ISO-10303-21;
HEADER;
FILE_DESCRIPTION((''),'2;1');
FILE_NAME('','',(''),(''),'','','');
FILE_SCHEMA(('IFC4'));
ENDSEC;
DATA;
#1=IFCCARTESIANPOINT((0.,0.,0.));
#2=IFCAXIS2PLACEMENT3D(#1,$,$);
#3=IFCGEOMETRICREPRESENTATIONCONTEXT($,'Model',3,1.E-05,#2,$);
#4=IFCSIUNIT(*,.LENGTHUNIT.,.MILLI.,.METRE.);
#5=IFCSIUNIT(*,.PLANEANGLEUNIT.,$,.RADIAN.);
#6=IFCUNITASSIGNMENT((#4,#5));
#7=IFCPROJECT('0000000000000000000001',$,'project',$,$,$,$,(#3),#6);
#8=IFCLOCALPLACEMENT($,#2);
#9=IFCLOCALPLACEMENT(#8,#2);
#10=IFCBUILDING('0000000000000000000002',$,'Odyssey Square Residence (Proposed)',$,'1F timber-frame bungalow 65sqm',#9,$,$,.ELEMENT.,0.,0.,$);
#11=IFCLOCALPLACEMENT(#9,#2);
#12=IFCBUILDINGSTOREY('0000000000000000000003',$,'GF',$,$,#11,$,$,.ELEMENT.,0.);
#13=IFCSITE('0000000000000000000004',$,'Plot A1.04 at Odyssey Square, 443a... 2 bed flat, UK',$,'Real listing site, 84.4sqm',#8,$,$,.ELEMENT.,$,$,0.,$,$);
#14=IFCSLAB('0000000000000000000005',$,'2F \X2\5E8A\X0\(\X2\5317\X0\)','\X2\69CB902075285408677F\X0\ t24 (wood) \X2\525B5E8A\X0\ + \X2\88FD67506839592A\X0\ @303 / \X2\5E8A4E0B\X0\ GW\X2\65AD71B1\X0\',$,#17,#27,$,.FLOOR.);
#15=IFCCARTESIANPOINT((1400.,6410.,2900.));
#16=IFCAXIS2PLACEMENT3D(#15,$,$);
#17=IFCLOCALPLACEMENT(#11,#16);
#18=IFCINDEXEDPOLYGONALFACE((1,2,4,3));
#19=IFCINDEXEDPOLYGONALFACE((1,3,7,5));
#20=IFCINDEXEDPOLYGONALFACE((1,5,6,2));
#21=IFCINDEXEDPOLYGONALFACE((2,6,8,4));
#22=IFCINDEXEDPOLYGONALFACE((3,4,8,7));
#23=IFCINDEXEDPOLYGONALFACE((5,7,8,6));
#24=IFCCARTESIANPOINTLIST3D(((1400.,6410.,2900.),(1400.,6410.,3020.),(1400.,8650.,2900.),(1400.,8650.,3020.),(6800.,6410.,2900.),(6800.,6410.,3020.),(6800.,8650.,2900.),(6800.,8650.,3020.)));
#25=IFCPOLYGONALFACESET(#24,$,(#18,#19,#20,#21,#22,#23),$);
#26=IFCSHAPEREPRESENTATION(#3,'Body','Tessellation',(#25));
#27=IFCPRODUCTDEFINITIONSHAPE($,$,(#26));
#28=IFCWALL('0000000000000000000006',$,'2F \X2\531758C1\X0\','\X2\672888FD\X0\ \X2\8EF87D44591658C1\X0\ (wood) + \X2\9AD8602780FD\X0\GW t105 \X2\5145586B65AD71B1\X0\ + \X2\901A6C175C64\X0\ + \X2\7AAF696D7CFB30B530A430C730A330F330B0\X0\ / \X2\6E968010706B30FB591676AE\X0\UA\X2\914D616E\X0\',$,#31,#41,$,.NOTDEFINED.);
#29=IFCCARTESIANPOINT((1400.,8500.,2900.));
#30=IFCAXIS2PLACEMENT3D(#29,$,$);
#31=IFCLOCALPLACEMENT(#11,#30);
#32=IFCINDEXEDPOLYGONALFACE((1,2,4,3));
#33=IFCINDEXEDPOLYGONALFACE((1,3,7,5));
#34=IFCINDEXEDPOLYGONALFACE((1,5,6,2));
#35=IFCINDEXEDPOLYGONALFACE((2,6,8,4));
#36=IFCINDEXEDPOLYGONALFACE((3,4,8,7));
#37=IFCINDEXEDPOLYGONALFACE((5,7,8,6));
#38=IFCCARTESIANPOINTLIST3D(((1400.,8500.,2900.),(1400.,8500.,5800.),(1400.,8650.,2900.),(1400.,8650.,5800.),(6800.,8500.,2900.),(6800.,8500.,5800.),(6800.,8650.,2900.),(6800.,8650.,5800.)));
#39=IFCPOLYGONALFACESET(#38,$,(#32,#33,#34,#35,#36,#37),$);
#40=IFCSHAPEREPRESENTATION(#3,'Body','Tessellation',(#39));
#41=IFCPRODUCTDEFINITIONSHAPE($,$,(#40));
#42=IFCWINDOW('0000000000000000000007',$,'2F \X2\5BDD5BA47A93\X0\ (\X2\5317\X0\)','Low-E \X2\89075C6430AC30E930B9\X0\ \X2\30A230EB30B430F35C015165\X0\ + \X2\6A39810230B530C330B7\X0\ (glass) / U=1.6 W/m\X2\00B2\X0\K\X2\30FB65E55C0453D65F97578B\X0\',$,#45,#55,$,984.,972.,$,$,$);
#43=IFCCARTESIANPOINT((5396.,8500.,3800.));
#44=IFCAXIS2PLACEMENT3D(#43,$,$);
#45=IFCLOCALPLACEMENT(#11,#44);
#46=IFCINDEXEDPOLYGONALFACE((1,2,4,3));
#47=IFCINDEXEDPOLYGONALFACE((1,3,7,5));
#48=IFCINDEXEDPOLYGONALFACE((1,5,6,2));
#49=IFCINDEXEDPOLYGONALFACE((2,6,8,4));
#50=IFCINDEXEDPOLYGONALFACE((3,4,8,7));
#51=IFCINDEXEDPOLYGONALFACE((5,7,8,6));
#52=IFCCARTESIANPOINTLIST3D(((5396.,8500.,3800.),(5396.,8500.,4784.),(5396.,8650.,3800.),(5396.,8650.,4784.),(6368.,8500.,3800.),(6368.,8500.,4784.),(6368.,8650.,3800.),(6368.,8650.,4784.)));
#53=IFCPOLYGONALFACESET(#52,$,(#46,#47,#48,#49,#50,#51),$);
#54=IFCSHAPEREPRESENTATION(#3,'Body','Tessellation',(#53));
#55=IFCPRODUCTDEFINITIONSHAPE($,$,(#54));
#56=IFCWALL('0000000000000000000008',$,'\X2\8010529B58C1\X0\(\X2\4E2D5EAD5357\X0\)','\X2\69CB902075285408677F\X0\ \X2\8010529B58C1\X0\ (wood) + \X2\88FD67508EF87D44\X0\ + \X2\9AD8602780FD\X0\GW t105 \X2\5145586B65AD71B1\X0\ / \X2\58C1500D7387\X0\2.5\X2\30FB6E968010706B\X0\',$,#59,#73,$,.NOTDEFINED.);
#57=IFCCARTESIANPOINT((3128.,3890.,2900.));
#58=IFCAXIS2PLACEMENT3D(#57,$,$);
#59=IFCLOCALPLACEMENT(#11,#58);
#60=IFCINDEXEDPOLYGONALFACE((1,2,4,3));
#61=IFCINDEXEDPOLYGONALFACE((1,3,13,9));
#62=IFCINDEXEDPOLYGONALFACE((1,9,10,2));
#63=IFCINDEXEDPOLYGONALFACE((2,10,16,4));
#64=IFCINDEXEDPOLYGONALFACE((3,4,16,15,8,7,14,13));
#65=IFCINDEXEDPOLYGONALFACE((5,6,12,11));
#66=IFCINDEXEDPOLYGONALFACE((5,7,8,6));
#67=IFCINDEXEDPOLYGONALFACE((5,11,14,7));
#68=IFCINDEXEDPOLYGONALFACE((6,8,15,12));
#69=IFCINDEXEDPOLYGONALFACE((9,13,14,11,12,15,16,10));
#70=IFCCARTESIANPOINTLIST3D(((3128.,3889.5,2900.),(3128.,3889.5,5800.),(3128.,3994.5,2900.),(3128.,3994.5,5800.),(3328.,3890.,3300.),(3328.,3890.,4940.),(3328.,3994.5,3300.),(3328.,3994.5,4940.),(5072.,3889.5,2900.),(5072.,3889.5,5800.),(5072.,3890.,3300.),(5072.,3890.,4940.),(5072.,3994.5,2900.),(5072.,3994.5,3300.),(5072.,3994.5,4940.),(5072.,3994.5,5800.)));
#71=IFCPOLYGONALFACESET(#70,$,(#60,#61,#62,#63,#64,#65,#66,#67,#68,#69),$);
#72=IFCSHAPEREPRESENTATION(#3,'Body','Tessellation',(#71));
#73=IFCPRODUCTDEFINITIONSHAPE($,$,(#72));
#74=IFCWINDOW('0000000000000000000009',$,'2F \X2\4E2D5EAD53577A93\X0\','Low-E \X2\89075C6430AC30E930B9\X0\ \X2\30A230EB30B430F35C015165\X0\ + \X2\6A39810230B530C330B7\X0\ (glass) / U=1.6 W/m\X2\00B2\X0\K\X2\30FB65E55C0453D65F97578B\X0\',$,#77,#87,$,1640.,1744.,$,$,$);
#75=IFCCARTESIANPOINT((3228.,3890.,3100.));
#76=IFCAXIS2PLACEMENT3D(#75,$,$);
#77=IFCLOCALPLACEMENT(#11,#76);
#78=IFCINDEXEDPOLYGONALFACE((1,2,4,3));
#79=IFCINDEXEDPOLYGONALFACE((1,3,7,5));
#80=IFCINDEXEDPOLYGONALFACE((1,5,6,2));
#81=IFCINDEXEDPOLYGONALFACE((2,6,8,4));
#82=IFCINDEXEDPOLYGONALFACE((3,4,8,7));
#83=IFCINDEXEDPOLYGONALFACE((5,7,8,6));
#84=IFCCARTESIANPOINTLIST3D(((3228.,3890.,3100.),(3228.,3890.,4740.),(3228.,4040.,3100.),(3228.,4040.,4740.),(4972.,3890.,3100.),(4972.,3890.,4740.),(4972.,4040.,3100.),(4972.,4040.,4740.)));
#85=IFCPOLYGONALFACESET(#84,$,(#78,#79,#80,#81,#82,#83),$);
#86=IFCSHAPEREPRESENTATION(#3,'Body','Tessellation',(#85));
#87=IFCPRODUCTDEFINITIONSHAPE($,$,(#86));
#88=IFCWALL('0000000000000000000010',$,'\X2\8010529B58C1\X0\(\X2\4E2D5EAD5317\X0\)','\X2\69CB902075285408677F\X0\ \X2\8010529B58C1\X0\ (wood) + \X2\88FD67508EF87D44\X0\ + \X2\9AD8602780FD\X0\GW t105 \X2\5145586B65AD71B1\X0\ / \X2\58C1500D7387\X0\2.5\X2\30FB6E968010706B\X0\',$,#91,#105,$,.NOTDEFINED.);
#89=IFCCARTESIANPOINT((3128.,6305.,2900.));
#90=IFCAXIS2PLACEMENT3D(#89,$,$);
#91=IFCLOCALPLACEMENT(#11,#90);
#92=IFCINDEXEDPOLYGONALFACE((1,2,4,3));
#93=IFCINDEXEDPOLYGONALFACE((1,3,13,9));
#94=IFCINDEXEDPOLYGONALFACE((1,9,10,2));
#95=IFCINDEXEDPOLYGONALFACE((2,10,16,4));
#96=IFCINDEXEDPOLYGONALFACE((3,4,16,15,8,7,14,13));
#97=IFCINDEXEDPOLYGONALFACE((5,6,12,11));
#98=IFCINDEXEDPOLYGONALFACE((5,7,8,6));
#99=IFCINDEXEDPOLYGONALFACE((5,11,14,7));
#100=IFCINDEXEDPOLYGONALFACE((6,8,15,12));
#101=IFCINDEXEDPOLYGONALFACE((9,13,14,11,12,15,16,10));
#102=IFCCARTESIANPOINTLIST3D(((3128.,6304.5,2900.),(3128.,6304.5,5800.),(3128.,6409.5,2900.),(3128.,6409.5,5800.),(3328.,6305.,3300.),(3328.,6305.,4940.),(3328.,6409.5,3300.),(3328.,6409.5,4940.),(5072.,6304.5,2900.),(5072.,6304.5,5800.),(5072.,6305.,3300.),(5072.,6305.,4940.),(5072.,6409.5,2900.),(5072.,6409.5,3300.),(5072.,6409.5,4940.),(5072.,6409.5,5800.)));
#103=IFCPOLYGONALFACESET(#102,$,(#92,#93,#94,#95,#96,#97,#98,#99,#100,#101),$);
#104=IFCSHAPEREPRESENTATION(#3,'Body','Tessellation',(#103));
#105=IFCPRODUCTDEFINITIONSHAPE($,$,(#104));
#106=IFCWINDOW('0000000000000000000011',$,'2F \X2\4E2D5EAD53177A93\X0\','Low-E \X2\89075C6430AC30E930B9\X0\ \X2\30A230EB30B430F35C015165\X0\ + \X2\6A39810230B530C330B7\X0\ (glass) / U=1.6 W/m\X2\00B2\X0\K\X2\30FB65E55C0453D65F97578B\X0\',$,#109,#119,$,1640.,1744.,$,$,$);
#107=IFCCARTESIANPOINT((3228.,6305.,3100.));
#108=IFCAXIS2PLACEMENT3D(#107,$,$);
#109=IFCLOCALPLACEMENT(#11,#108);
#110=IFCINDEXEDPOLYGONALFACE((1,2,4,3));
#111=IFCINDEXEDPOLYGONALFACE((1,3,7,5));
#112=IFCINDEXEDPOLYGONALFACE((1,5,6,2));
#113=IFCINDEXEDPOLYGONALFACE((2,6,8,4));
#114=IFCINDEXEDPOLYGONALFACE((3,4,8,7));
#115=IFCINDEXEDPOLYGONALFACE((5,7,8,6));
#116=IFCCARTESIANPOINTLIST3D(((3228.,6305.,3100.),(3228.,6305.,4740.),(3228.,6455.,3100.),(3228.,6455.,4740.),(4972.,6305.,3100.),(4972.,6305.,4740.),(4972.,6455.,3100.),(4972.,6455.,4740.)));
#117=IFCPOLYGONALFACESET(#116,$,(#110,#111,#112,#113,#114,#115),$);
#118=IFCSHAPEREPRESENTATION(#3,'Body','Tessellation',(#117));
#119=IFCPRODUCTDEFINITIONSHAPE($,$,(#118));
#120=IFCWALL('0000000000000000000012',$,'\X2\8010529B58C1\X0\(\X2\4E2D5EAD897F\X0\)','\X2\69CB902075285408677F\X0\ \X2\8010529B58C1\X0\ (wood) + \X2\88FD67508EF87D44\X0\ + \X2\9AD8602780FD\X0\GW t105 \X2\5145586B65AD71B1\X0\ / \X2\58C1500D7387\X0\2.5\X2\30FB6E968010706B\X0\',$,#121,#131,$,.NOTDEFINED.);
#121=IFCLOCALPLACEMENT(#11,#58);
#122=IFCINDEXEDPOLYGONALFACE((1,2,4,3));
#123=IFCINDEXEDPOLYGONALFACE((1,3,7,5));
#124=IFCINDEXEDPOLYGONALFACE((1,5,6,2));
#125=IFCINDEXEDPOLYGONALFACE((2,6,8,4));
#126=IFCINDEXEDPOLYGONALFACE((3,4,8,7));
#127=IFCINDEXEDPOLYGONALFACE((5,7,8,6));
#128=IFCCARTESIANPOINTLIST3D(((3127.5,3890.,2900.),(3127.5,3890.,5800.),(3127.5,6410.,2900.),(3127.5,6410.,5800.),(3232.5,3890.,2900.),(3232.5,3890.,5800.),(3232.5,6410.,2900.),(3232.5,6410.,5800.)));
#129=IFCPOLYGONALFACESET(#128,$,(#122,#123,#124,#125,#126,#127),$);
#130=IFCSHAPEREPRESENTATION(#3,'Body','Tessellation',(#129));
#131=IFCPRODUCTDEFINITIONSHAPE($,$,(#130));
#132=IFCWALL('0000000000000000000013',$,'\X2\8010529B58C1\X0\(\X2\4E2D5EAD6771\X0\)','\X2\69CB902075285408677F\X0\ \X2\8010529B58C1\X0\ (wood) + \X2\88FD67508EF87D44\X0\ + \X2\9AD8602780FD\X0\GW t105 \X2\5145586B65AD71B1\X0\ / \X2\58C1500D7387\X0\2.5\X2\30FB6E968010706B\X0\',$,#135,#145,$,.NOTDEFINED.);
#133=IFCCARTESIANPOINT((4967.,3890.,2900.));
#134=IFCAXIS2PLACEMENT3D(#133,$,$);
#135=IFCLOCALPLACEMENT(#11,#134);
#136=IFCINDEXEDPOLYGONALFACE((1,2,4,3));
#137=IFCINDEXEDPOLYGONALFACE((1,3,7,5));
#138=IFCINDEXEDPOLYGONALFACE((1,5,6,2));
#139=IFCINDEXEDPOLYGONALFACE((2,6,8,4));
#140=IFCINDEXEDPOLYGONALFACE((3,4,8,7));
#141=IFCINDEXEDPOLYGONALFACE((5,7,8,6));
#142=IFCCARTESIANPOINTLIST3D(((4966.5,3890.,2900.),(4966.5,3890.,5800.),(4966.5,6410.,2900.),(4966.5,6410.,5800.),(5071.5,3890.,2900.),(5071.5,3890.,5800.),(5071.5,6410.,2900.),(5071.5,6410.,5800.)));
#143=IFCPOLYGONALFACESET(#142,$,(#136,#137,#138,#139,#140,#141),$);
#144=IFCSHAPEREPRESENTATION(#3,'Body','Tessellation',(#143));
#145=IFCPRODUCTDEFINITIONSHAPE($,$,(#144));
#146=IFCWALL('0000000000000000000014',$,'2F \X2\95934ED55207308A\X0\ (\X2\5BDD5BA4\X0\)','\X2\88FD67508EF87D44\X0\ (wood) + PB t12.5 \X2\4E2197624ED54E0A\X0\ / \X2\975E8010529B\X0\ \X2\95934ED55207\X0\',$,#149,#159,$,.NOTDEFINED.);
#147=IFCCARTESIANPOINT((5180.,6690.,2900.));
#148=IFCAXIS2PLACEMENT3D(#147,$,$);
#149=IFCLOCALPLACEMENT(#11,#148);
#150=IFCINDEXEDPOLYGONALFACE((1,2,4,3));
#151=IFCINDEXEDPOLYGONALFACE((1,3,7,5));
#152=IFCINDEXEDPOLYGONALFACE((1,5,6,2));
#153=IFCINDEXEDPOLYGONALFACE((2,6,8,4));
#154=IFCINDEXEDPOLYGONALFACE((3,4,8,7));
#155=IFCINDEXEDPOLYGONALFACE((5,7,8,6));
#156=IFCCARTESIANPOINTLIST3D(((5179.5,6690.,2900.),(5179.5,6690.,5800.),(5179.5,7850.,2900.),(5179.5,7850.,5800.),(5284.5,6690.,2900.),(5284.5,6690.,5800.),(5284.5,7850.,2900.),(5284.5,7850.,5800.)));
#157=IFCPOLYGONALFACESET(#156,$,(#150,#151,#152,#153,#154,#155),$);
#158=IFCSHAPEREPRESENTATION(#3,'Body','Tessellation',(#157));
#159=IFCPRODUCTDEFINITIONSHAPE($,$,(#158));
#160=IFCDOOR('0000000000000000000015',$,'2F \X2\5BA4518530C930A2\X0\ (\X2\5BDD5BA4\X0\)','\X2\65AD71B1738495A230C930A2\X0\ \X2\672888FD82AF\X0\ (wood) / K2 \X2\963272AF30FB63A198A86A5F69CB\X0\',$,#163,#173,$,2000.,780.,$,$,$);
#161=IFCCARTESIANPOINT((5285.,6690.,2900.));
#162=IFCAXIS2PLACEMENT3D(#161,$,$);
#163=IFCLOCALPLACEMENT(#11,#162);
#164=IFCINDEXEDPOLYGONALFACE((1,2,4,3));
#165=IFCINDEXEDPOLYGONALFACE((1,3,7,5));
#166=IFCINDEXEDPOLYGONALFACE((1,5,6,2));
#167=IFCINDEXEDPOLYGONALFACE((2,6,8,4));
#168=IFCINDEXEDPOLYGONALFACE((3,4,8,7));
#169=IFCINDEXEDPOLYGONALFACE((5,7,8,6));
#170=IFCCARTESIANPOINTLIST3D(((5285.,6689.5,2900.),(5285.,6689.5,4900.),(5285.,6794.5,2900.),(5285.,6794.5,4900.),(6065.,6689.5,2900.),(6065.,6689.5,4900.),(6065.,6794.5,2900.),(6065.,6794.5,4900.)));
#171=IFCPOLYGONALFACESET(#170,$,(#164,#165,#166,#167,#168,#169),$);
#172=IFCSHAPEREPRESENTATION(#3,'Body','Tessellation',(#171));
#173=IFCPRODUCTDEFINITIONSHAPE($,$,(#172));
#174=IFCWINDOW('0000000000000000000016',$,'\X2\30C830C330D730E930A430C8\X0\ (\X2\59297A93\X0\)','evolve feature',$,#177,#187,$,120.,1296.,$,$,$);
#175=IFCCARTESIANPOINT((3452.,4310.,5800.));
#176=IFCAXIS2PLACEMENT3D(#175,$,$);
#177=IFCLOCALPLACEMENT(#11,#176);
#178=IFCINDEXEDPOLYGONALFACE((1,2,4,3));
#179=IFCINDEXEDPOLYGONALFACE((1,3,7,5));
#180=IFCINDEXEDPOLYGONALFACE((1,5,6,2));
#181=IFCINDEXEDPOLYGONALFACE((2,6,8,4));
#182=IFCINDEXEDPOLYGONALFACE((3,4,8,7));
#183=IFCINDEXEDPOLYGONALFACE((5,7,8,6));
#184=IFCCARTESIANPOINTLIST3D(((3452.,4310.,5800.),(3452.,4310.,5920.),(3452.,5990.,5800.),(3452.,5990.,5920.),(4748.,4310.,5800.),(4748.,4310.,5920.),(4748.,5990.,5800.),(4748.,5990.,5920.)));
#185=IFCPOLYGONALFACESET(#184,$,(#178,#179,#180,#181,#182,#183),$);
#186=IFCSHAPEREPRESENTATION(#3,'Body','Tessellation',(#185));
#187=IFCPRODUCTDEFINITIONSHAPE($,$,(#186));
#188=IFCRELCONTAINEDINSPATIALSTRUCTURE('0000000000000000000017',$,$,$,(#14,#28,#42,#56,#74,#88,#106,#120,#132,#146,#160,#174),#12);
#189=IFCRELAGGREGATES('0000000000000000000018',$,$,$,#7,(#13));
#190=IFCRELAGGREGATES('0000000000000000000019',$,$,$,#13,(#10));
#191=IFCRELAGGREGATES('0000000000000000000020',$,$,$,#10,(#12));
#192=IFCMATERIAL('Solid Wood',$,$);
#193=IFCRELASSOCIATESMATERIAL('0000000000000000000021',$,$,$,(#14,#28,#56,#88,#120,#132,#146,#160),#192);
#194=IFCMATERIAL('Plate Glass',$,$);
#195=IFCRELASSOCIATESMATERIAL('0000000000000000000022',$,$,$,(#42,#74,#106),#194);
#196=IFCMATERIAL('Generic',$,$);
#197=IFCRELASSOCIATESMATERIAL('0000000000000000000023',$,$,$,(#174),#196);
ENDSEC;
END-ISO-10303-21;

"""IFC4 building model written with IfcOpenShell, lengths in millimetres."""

from ifc_helpers import new_model, si_unit, frame, frame_2d, origin, place, context, project, spatial, rectangle, extrude, material, element, fill, save


model = new_model("IFC4")

# Units and contexts
model_context = context("Model", 3, precision=1e-05, world=origin())
ifc_project = project(units=[si_unit("LENGTHUNIT", "METRE", prefix="MILLI"), si_unit("PLANEANGLEUNIT", "RADIAN")], contexts=[model_context])

# Site, building, storey
site_placement = place(None, origin())
site = spatial("IfcSite", under=ifc_project, at=site_placement, Name="Plot A1.04 at Odyssey Square, 443a... 2 bed flat, UK", ObjectType="Real listing site, 84.4sqm", CompositionType="ELEMENT", RefElevation=0.0)
building_placement = place(site_placement, origin())
building = spatial("IfcBuilding", under=site, at=building_placement, Name="Odyssey Square Residence (Proposed)", ObjectType="1F timber-frame bungalow 65sqm", CompositionType="ELEMENT", ElevationOfRefHeight=0.0, ElevationOfTerrain=0.0)
storey_placement = place(building_placement, origin())
storey = spatial("IfcBuildingStorey", under=building, at=storey_placement, Name="GF", CompositionType="ELEMENT", Elevation=0.0)

# Slab
ifc_material_1 = material(Name="Solid Wood")
slab_placement = place(storey_placement, frame((1400.0, 6410.0, 2900.0)))
element("IfcSlab", 1, at=slab_placement, inside=storey, material=ifc_material_1, Name="2F 床(北)", Description="構造用合板 t24 (wood) 剛床 + 製材根太 @303 / 床下 GW断熱", PredefinedType="FLOOR", context=model_context, shape_type="SweptSolid", body=[
    extrude(rectangle(XDim=5400.0, YDim=2240.0, at=frame_2d((2700.0, 1120.0))), frame((1400.0, 6410.0, 2900.0)), (0.0, 0.0, 1.0), 120.0),
])

# Walls, openings, windows
wall_1_placement = place(storey_placement, frame((1400.0, 8500.0, 2900.0)))
wall_1 = element("IfcWall", 2, at=wall_1_placement, inside=storey, material=ifc_material_1, Name="2F 北壁", Description="木製 軸組外壁 (wood) + 高性能GW t105 充填断熱 + 通気層 + 窯業系サイディング / 準耐火・外皮UA配慮", PredefinedType="NOTDEFINED", context=model_context, shape_type="SweptSolid", body=[
    extrude(rectangle(XDim=5400.0, YDim=150.0, at=frame_2d((2700.0, 75.0))), frame((1400.0, 8500.0, 2900.0)), (0.0, 0.0, 1.0), 2900.0),
])
opening_1_placement = place(storey_placement, frame((5396.0, 8500.0, 3800.0)))
opening_1 = element("IfcOpeningElement", 3, at=opening_1_placement, cuts=wall_1, PredefinedType="NOTDEFINED", context=model_context, shape_type="SweptSolid", body=[
    extrude(rectangle(XDim=972.0, YDim=150.0, at=frame_2d((486.0, 75.0))), frame((5396.0, 8500.0, 3800.0)), (0.0, 0.0, 1.0), 984.0),
])
ifc_material_2 = material(Name="Plate Glass")
window_1_placement = place(storey_placement, frame((5396.0, 8500.0, 3800.0)))
window_1 = element("IfcWindow", 4, at=window_1_placement, inside=storey, material=ifc_material_2, Name="2F 寝室窓 (北)", Description="Low-E 複層ガラス アルゴン封入 + 樹脂サッシ (glass) / U=1.6 W/m²K・日射取得型", OverallHeight=984.0, OverallWidth=972.0, context=model_context, shape_type="SweptSolid", body=[
    extrude(rectangle(XDim=972.0, YDim=150.0, at=frame_2d((486.0, 75.0))), frame((5396.0, 8500.0, 3800.0)), (0.0, 0.0, 1.0), 984.0),
])
fill(opening_1, window_1)
wall_2_placement = place(storey_placement, frame((3128.0, 3890.0, 2900.0)))
wall_2 = element("IfcWall", 5, at=wall_2_placement, inside=storey, material=ifc_material_1, Name="耐力壁(中庭南)", Description="構造用合板 耐力壁 (wood) + 製材軸組 + 高性能GW t105 充填断熱 / 壁倍率2.5・準耐火", PredefinedType="NOTDEFINED", context=model_context, shape_type="SweptSolid", body=[
    extrude(rectangle(XDim=1944.0, YDim=105.0, at=frame_2d((972.0, 52.0))), frame((3128.0, 3890.0, 2900.0)), (0.0, 0.0, 1.0), 2900.0),
])
opening_2_placement = place(storey_placement, frame((3228.0, 3890.0, 3100.0)))
opening_2 = element("IfcOpeningElement", 6, at=opening_2_placement, cuts=wall_2, PredefinedType="NOTDEFINED", context=model_context, shape_type="SweptSolid", body=[
    extrude(rectangle(XDim=1744.0, YDim=150.0, at=frame_2d((872.0, 75.0))), frame((3228.0, 3890.0, 3100.0)), (0.0, 0.0, 1.0), 1640.0),
])
window_2_placement = place(storey_placement, frame((3228.0, 3890.0, 3100.0)))
window_2 = element("IfcWindow", 7, at=window_2_placement, inside=storey, material=ifc_material_2, Name="2F 中庭南窓", Description="Low-E 複層ガラス アルゴン封入 + 樹脂サッシ (glass) / U=1.6 W/m²K・日射取得型", OverallHeight=1640.0, OverallWidth=1744.0, context=model_context, shape_type="SweptSolid", body=[
    extrude(rectangle(XDim=1744.0, YDim=150.0, at=frame_2d((872.0, 75.0))), frame((3228.0, 3890.0, 3100.0)), (0.0, 0.0, 1.0), 1640.0),
])
fill(opening_2, window_2)
wall_3_placement = place(storey_placement, frame((3128.0, 6305.0, 2900.0)))
wall_3 = element("IfcWall", 8, at=wall_3_placement, inside=storey, material=ifc_material_1, Name="耐力壁(中庭北)", Description="構造用合板 耐力壁 (wood) + 製材軸組 + 高性能GW t105 充填断熱 / 壁倍率2.5・準耐火", PredefinedType="NOTDEFINED", context=model_context, shape_type="SweptSolid", body=[
    extrude(rectangle(XDim=1944.0, YDim=105.0, at=frame_2d((972.0, 52.0))), frame((3128.0, 6305.0, 2900.0)), (0.0, 0.0, 1.0), 2900.0),
])
opening_3_placement = place(storey_placement, frame((3228.0, 6305.0, 3100.0)))
opening_3 = element("IfcOpeningElement", 9, at=opening_3_placement, cuts=wall_3, PredefinedType="NOTDEFINED", context=model_context, shape_type="SweptSolid", body=[
    extrude(rectangle(XDim=1744.0, YDim=150.0, at=frame_2d((872.0, 75.0))), frame((3228.0, 6305.0, 3100.0)), (0.0, 0.0, 1.0), 1640.0),
])
window_3_placement = place(storey_placement, frame((3228.0, 6305.0, 3100.0)))
window_3 = element("IfcWindow", 10, at=window_3_placement, inside=storey, material=ifc_material_2, Name="2F 中庭北窓", Description="Low-E 複層ガラス アルゴン封入 + 樹脂サッシ (glass) / U=1.6 W/m²K・日射取得型", OverallHeight=1640.0, OverallWidth=1744.0, context=model_context, shape_type="SweptSolid", body=[
    extrude(rectangle(XDim=1744.0, YDim=150.0, at=frame_2d((872.0, 75.0))), frame((3228.0, 6305.0, 3100.0)), (0.0, 0.0, 1.0), 1640.0),
])
fill(opening_3, window_3)

# Walls
wall_4_placement = place(storey_placement, frame((3128.0, 3890.0, 2900.0)))
element("IfcWall", 11, at=wall_4_placement, inside=storey, material=ifc_material_1, Name="耐力壁(中庭西)", Description="構造用合板 耐力壁 (wood) + 製材軸組 + 高性能GW t105 充填断熱 / 壁倍率2.5・準耐火", PredefinedType="NOTDEFINED", context=model_context, shape_type="SweptSolid", body=[
    extrude(rectangle(XDim=105.0, YDim=2520.0, at=frame_2d((52.0, 1260.0))), frame((3128.0, 3890.0, 2900.0)), (0.0, 0.0, 1.0), 2900.0),
])
wall_5_placement = place(storey_placement, frame((4967.0, 3890.0, 2900.0)))
element("IfcWall", 12, at=wall_5_placement, inside=storey, material=ifc_material_1, Name="耐力壁(中庭東)", Description="構造用合板 耐力壁 (wood) + 製材軸組 + 高性能GW t105 充填断熱 / 壁倍率2.5・準耐火", PredefinedType="NOTDEFINED", context=model_context, shape_type="SweptSolid", body=[
    extrude(rectangle(XDim=105.0, YDim=2520.0, at=frame_2d((52.0, 1260.0))), frame((4967.0, 3890.0, 2900.0)), (0.0, 0.0, 1.0), 2900.0),
])
wall_6_placement = place(storey_placement, frame((5180.0, 6690.0, 2900.0)))
element("IfcWall", 13, at=wall_6_placement, inside=storey, material=ifc_material_1, Name="2F 間仕切り (寝室)", Description="製材軸組 (wood) + PB t12.5 両面仕上 / 非耐力 間仕切", PredefinedType="NOTDEFINED", context=model_context, shape_type="SweptSolid", body=[
    extrude(rectangle(XDim=105.0, YDim=1160.0, at=frame_2d((52.0, 580.0))), frame((5180.0, 6690.0, 2900.0)), (0.0, 0.0, 1.0), 2900.0),
])

# Door
door_placement = place(storey_placement, frame((5285.0, 6690.0, 2900.0)))
element("IfcDoor", 14, at=door_placement, inside=storey, material=ifc_material_1, Name="2F 室内ドア (寝室)", Description="断熱玄関ドア 木製芯 (wood) / K2 防犯・採風機構", OverallHeight=2000.0, OverallWidth=780.0, context=model_context, shape_type="SweptSolid", body=[
    extrude(rectangle(XDim=780.0, YDim=105.0, at=frame_2d((390.0, 52.0))), frame((5285.0, 6690.0, 2900.0)), (0.0, 0.0, 1.0), 2000.0),
])

# Window
ifc_material_3 = material(Name="Generic")
window_4_placement = place(storey_placement, frame((3452.0, 4310.0, 5800.0)))
element("IfcWindow", 15, at=window_4_placement, inside=storey, material=ifc_material_3, Name="トップライト (天窓)", Description="evolve feature", OverallHeight=120.0, OverallWidth=1296.0, context=model_context, shape_type="SweptSolid", body=[
    extrude(rectangle(XDim=1296.0, YDim=1680.0, at=frame_2d((648.0, 840.0))), frame((3452.0, 4310.0, 5800.0)), (0.0, 0.0, 1.0), 120.0),
])

save(model, "model.ifc")
